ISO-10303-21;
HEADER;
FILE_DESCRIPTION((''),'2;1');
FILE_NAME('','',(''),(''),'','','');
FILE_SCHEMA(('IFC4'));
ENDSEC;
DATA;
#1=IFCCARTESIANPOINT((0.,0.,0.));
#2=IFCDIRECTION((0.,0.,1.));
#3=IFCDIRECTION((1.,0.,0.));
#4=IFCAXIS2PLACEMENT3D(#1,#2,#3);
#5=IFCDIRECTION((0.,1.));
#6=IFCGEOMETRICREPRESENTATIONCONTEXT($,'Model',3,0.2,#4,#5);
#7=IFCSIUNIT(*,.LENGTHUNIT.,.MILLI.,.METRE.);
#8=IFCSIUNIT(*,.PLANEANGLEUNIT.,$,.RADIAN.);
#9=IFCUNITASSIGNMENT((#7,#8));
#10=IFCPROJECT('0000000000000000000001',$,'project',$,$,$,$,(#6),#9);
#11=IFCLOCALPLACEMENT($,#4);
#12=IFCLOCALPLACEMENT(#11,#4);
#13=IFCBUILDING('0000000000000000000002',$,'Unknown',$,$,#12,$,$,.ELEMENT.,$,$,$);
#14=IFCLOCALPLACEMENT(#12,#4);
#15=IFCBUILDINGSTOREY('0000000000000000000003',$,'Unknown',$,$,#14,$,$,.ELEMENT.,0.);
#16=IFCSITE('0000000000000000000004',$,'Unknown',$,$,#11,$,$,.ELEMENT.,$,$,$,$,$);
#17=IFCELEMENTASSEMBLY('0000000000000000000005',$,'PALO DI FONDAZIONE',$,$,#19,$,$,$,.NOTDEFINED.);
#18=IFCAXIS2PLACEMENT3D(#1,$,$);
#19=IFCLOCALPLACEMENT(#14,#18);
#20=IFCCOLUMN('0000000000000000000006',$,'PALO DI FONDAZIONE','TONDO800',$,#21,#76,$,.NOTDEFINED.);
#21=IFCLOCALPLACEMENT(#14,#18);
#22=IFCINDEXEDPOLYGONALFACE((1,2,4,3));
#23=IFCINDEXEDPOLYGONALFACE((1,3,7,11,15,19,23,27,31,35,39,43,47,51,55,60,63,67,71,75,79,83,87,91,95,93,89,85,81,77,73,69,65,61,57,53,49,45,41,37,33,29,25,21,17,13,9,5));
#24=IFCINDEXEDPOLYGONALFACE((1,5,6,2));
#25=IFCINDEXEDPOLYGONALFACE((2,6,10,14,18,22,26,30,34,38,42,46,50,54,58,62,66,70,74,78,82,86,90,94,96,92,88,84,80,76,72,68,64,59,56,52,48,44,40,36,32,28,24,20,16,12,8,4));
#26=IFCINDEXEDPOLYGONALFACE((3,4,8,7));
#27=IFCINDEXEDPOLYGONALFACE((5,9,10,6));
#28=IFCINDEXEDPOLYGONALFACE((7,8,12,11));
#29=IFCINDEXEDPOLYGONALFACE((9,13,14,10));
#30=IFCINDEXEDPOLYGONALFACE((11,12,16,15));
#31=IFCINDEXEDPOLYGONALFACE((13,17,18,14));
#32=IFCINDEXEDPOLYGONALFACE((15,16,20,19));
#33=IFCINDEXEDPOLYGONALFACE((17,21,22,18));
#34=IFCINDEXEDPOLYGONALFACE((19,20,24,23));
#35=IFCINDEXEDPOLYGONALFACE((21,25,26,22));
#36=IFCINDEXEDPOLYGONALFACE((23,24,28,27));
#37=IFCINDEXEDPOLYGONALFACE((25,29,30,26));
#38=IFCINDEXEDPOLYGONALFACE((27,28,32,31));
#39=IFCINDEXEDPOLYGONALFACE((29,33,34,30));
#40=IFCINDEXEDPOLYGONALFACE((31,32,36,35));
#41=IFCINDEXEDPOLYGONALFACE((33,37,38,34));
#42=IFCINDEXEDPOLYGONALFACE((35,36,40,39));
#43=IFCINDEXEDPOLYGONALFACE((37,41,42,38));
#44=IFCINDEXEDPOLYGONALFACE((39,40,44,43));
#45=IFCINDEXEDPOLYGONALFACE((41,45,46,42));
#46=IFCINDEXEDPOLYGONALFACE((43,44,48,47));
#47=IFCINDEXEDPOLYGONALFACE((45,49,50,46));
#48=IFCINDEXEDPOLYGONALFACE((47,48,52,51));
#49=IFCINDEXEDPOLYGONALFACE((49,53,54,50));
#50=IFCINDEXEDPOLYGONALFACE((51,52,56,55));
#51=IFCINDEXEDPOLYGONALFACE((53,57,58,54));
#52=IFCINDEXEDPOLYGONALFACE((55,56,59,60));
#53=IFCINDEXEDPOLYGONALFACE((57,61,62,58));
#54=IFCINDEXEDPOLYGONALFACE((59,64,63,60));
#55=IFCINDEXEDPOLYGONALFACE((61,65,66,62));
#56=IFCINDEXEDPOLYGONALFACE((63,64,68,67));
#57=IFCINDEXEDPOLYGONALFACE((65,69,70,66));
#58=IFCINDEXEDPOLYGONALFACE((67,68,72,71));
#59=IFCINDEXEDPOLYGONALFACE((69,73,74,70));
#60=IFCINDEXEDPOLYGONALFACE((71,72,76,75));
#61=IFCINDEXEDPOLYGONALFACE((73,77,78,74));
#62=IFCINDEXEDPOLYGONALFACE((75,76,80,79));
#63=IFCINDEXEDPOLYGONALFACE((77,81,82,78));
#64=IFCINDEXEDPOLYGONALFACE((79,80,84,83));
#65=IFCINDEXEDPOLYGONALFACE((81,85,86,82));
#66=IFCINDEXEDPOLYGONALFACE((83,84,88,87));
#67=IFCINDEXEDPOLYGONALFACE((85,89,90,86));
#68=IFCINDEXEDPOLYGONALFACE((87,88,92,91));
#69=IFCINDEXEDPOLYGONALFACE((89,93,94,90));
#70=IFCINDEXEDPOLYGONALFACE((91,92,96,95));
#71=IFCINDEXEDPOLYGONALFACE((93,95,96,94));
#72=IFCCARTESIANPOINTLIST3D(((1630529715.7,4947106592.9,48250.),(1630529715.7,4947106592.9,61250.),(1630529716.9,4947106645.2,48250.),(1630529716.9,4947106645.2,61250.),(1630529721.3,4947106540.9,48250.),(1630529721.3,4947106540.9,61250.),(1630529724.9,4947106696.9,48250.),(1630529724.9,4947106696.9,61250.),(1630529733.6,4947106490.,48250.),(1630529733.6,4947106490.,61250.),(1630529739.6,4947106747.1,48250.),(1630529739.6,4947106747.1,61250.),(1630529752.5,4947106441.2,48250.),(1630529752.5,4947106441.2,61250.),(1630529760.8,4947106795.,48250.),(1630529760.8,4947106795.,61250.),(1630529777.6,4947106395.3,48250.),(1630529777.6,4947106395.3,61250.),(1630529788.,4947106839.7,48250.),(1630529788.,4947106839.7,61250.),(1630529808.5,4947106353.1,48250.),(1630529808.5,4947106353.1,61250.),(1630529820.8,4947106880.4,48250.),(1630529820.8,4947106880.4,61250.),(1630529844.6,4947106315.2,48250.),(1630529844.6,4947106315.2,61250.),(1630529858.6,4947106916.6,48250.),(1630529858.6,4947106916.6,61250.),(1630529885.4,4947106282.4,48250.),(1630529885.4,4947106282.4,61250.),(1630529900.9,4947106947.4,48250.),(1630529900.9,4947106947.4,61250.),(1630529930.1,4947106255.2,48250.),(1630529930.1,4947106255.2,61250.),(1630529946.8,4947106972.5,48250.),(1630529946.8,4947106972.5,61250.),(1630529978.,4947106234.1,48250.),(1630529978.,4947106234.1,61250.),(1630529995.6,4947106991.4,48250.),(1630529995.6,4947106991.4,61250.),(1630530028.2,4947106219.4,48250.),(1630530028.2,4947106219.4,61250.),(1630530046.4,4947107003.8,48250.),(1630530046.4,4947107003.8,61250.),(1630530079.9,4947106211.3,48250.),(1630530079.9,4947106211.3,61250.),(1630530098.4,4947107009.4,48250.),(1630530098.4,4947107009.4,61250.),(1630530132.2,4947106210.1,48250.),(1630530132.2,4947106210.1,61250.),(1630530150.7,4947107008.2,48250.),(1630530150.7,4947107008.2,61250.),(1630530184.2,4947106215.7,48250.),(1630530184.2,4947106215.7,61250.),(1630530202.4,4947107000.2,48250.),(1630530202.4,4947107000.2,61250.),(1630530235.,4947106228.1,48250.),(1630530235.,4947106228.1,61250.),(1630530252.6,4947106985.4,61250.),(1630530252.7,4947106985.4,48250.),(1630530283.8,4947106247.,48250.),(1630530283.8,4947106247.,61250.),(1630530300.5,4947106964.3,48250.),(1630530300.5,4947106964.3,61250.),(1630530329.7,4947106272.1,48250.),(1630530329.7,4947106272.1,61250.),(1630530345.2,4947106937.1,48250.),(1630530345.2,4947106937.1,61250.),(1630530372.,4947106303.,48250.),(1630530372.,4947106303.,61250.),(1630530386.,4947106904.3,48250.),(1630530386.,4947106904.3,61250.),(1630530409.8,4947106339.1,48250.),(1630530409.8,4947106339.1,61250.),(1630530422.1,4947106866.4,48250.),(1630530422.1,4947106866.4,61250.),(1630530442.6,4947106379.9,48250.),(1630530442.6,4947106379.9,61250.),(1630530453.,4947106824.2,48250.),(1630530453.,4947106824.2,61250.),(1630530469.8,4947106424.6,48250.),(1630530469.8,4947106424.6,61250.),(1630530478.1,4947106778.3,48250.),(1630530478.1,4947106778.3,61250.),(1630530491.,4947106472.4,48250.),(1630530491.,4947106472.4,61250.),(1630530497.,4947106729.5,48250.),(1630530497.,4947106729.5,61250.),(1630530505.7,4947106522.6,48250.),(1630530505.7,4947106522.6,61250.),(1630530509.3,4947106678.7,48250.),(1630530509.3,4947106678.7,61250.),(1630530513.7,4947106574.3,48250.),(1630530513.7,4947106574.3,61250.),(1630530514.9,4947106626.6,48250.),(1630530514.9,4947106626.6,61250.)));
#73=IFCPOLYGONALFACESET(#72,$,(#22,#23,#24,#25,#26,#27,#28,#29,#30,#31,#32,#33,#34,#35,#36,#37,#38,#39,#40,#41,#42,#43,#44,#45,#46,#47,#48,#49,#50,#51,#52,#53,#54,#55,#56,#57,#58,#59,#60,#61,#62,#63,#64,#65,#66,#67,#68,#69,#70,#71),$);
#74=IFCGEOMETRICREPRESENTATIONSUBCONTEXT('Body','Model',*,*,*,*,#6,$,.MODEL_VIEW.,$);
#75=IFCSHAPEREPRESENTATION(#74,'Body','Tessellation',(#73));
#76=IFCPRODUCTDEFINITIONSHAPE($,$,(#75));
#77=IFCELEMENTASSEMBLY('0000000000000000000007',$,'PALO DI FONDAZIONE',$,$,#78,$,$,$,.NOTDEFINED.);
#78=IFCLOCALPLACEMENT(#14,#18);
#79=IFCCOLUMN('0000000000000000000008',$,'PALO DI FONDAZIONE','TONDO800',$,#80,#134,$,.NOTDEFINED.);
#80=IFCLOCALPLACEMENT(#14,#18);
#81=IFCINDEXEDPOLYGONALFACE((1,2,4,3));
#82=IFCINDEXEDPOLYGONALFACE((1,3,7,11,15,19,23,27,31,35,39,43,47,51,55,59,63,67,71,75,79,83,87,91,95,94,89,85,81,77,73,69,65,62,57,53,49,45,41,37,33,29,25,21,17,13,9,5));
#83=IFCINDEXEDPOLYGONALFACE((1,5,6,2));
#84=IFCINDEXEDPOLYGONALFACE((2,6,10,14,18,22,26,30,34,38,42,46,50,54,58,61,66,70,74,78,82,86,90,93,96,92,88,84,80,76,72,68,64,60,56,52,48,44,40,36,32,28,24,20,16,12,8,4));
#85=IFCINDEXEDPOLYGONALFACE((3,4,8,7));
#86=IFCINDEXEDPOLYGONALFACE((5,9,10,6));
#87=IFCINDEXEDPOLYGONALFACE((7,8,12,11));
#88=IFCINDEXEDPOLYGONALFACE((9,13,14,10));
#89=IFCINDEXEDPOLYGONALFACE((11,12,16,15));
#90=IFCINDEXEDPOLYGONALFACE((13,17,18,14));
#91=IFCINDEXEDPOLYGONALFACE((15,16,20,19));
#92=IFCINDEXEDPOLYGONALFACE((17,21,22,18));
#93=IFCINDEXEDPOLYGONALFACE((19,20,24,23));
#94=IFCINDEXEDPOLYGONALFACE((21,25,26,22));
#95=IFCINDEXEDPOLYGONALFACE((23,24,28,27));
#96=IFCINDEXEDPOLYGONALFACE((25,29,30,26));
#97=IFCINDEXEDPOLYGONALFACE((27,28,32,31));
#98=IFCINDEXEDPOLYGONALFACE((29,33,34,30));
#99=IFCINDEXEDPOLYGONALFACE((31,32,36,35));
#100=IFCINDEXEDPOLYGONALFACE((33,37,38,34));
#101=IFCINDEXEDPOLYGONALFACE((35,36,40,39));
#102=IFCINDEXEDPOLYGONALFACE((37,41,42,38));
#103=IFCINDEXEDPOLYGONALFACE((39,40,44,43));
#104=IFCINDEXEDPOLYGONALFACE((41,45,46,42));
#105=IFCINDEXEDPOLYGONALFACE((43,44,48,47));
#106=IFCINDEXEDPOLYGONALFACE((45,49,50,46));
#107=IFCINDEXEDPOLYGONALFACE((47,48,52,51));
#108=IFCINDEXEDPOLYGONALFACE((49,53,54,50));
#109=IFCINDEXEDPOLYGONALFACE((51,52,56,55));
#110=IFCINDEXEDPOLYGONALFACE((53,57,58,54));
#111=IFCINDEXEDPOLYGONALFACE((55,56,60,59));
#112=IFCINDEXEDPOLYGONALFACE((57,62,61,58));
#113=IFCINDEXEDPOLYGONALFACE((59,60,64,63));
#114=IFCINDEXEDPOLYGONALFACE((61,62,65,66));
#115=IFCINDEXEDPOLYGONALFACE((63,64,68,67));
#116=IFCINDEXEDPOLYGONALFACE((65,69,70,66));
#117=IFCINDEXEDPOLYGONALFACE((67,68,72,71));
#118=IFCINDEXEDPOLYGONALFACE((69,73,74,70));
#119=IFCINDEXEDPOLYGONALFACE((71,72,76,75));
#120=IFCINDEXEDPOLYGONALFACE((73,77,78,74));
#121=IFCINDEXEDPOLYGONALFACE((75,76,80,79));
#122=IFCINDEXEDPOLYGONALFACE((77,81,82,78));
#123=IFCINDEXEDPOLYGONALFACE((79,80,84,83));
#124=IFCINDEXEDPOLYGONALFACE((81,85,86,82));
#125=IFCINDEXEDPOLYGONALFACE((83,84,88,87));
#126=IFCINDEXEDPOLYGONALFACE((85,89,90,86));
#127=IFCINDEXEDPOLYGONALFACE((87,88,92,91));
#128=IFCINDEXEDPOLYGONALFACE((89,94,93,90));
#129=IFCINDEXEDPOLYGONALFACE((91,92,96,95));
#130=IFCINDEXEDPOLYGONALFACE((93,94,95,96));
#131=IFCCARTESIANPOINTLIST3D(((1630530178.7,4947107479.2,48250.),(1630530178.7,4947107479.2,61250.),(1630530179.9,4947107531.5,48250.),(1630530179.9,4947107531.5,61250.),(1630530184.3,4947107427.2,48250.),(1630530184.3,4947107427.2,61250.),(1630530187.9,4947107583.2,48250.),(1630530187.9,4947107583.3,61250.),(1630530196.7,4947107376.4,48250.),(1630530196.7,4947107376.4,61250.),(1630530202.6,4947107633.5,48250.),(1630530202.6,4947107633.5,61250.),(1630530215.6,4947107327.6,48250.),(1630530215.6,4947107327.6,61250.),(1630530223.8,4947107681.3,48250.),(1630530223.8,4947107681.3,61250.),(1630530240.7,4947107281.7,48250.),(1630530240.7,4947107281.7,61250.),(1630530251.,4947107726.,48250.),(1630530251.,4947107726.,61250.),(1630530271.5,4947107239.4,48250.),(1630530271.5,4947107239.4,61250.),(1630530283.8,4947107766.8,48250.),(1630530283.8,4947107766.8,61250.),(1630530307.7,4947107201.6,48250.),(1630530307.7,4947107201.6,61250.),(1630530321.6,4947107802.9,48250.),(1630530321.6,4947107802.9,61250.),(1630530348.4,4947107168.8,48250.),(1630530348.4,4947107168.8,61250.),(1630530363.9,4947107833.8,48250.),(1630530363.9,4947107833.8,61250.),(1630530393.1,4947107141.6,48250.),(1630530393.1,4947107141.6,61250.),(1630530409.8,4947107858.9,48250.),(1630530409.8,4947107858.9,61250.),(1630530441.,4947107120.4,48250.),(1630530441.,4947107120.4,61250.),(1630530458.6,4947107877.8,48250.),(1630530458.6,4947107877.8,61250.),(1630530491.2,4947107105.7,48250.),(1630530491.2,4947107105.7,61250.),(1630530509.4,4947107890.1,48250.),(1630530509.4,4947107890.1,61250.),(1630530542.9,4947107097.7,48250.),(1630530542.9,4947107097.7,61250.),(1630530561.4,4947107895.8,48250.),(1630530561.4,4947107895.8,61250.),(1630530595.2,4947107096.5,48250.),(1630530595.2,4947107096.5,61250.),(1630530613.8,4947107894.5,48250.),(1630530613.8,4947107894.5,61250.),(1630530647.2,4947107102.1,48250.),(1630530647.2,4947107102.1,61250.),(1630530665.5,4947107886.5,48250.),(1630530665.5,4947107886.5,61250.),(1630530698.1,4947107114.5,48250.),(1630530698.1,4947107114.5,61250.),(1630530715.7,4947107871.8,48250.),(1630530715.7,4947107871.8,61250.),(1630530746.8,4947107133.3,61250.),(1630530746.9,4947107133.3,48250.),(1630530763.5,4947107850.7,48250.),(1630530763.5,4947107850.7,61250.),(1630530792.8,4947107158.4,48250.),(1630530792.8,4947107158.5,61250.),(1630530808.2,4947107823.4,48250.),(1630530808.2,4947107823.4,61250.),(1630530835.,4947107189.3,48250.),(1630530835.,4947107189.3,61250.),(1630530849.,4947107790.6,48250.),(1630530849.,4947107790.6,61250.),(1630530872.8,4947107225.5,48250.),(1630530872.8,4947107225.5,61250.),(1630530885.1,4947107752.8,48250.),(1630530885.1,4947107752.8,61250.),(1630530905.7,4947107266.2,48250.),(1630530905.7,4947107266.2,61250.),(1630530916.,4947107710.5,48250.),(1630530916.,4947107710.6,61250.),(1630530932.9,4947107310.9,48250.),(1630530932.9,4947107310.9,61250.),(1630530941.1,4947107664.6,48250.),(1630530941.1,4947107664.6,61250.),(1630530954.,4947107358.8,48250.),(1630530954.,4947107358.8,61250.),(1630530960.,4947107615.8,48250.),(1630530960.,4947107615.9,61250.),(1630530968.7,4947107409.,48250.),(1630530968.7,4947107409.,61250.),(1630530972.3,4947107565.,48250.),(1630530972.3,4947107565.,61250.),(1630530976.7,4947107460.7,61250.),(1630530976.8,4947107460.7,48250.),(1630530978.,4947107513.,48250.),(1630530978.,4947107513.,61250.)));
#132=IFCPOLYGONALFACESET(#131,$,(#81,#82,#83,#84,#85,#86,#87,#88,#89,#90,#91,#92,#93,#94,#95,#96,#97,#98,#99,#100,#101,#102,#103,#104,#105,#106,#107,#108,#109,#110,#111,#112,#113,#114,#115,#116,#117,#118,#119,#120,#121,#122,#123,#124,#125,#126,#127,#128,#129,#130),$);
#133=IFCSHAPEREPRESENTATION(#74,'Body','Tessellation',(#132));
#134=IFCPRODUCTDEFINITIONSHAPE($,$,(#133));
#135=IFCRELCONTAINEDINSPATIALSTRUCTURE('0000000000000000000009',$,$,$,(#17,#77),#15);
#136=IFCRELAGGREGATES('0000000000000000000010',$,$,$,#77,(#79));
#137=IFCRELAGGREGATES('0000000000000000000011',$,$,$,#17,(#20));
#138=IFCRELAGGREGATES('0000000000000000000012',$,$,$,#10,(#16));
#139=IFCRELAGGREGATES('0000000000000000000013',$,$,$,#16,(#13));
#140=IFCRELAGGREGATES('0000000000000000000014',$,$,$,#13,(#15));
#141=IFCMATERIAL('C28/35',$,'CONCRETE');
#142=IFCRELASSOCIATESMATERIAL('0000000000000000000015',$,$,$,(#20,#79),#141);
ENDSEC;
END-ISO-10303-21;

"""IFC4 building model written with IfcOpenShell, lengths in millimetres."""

from ifc_helpers import new_model, si_unit, direction, frame, origin_with_axes, place, context, subcontext, project, spatial, line, indexed_curve, outline, extrude, material, element, aggregate, save


model = new_model("IFC4")

# Units and contexts
model_context = context("Model", 3, precision=0.2, world=origin_with_axes(), true_north=direction((0.0, 1.0)))
body_context = subcontext(model_context, "Body", "Model", "MODEL_VIEW")
ifc_project = project(units=[si_unit("LENGTHUNIT", "METRE", prefix="MILLI"), si_unit("PLANEANGLEUNIT", "RADIAN")], contexts=[model_context])

# Site, building, storey
site_placement = place(None, origin_with_axes())
site = spatial("IfcSite", under=ifc_project, at=site_placement, Name="Unknown", CompositionType="ELEMENT")
building_placement = place(site_placement, origin_with_axes())
building = spatial("IfcBuilding", under=site, at=building_placement, Name="Unknown", CompositionType="ELEMENT")
storey_placement = place(building_placement, origin_with_axes())
storey = spatial("IfcBuildingStorey", under=building, at=storey_placement, Name="Unknown", CompositionType="ELEMENT", Elevation=0.0)

# Element assemblies, columns
assembly_1_placement = place(storey_placement, frame((1630530115.3, 4947106609.8, 48250.0), z_axis=(-0.463019, -0.886348, 0.0), x_axis=(0.0, 0.0, 1.0)))
assembly_1 = element("IfcElementAssembly", 1, at=assembly_1_placement, inside=storey, Name="PALO DI FONDAZIONE", PredefinedType="NOTDEFINED")
ifc_material_1 = material(Name="C28/35", Category="CONCRETE")
column_1_placement = place(assembly_1_placement, origin_with_axes())
column_1 = element("IfcColumn", 2, at=column_1_placement, material=ifc_material_1, Name="PALO DI FONDAZIONE", Description="TONDO800", PredefinedType="NOTDEFINED", context=body_context, shape_type="SolidModel", body=[
    extrude(outline(indexed_curve([(400.0, 0.0), (396.6, 52.2), (386.4, 103.5), (369.6, 153.1), (346.4, 200.0), (317.3, 243.5), (282.8, 282.8), (243.5, 317.3), (200.0, 346.4), (153.1, 369.6), (103.5, 386.4), (52.2, 396.6), (0.0, 400.0), (-52.2, 396.6), (-103.5, 386.4), (-153.1, 369.6), (-200.0, 346.4), (-243.5, 317.3), (-282.8, 282.8), (-317.3, 243.5), (-346.4, 200.0), (-369.6, 153.1), (-386.4, 103.5), (-396.6, 52.2), (-400.0, 0.0), (-396.6, -52.2), (-386.4, -103.5), (-369.6, -153.1), (-346.4, -200.0), (-317.3, -243.5), (-282.8, -282.8), (-243.5, -317.3), (-200.0, -346.4), (-153.1, -369.6), (-103.5, -386.4), (-52.2, -396.6), (0.0, -400.0), (52.2, -396.6), (103.5, -386.4), (153.1, -369.6), (200.0, -346.4), (243.5, -317.3), (282.8, -282.8), (317.3, -243.5), (346.4, -200.0), (369.6, -153.1), (386.4, -103.5), (396.6, -52.2)], segments=[line(1, 2, 3, 4, 5, 6, 7, 8, 9, 10, 11, 12, 13, 14, 15, 16, 17, 18, 19, 20, 21, 22, 23, 24, 25, 26, 27, 28, 29, 30, 31, 32, 33, 34, 35, 36, 37, 38, 39, 40, 41, 42, 43, 44, 45, 46, 47, 48, 1)])), frame((0.0, 0.0, 0.0), z_axis=(-1.0, 0.0, 0.0), x_axis=(0.0, 0.0, 1.0)), (0.0, 0.0, -1.0), 13000.0),
])
assembly_2_placement = place(storey_placement, frame((1630530578.3, 4947107496.1, 48250.0), z_axis=(-0.463019, -0.886348, 0.0), x_axis=(0.0, 0.0, 1.0)))
assembly_2 = element("IfcElementAssembly", 3, at=assembly_2_placement, inside=storey, Name="PALO DI FONDAZIONE", PredefinedType="NOTDEFINED")
column_2_placement = place(assembly_2_placement, origin_with_axes())
column_2 = element("IfcColumn", 4, at=column_2_placement, material=ifc_material_1, Name="PALO DI FONDAZIONE", Description="TONDO800", PredefinedType="NOTDEFINED", context=body_context, shape_type="SolidModel", body=[
    extrude(outline(indexed_curve([(400.0, 0.0), (396.6, 52.2), (386.4, 103.5), (369.6, 153.1), (346.4, 200.0), (317.3, 243.5), (282.8, 282.8), (243.5, 317.3), (200.0, 346.4), (153.1, 369.6), (103.5, 386.4), (52.2, 396.6), (0.0, 400.0), (-52.2, 396.6), (-103.5, 386.4), (-153.1, 369.6), (-200.0, 346.4), (-243.5, 317.3), (-282.8, 282.8), (-317.3, 243.5), (-346.4, 200.0), (-369.6, 153.1), (-386.4, 103.5), (-396.6, 52.2), (-400.0, 0.0), (-396.6, -52.2), (-386.4, -103.5), (-369.6, -153.1), (-346.4, -200.0), (-317.3, -243.5), (-282.8, -282.8), (-243.5, -317.3), (-200.0, -346.4), (-153.1, -369.6), (-103.5, -386.4), (-52.2, -396.6), (0.0, -400.0), (52.2, -396.6), (103.5, -386.4), (153.1, -369.6), (200.0, -346.4), (243.5, -317.3), (282.8, -282.8), (317.3, -243.5), (346.4, -200.0), (369.6, -153.1), (386.4, -103.5), (396.6, -52.2)], segments=[line(1, 2, 3, 4, 5, 6, 7, 8, 9, 10, 11, 12, 13, 14, 15, 16, 17, 18, 19, 20, 21, 22, 23, 24, 25, 26, 27, 28, 29, 30, 31, 32, 33, 34, 35, 36, 37, 38, 39, 40, 41, 42, 43, 44, 45, 46, 47, 48, 1)])), frame((0.0, 0.0, 0.0), z_axis=(-1.0, 0.0, 0.0), x_axis=(0.0, 0.0, 1.0)), (0.0, 0.0, -1.0), 13000.0),
])
aggregate(assembly_2, [column_2])

aggregate(assembly_1, [column_1])

save(model, "model.ifc")
